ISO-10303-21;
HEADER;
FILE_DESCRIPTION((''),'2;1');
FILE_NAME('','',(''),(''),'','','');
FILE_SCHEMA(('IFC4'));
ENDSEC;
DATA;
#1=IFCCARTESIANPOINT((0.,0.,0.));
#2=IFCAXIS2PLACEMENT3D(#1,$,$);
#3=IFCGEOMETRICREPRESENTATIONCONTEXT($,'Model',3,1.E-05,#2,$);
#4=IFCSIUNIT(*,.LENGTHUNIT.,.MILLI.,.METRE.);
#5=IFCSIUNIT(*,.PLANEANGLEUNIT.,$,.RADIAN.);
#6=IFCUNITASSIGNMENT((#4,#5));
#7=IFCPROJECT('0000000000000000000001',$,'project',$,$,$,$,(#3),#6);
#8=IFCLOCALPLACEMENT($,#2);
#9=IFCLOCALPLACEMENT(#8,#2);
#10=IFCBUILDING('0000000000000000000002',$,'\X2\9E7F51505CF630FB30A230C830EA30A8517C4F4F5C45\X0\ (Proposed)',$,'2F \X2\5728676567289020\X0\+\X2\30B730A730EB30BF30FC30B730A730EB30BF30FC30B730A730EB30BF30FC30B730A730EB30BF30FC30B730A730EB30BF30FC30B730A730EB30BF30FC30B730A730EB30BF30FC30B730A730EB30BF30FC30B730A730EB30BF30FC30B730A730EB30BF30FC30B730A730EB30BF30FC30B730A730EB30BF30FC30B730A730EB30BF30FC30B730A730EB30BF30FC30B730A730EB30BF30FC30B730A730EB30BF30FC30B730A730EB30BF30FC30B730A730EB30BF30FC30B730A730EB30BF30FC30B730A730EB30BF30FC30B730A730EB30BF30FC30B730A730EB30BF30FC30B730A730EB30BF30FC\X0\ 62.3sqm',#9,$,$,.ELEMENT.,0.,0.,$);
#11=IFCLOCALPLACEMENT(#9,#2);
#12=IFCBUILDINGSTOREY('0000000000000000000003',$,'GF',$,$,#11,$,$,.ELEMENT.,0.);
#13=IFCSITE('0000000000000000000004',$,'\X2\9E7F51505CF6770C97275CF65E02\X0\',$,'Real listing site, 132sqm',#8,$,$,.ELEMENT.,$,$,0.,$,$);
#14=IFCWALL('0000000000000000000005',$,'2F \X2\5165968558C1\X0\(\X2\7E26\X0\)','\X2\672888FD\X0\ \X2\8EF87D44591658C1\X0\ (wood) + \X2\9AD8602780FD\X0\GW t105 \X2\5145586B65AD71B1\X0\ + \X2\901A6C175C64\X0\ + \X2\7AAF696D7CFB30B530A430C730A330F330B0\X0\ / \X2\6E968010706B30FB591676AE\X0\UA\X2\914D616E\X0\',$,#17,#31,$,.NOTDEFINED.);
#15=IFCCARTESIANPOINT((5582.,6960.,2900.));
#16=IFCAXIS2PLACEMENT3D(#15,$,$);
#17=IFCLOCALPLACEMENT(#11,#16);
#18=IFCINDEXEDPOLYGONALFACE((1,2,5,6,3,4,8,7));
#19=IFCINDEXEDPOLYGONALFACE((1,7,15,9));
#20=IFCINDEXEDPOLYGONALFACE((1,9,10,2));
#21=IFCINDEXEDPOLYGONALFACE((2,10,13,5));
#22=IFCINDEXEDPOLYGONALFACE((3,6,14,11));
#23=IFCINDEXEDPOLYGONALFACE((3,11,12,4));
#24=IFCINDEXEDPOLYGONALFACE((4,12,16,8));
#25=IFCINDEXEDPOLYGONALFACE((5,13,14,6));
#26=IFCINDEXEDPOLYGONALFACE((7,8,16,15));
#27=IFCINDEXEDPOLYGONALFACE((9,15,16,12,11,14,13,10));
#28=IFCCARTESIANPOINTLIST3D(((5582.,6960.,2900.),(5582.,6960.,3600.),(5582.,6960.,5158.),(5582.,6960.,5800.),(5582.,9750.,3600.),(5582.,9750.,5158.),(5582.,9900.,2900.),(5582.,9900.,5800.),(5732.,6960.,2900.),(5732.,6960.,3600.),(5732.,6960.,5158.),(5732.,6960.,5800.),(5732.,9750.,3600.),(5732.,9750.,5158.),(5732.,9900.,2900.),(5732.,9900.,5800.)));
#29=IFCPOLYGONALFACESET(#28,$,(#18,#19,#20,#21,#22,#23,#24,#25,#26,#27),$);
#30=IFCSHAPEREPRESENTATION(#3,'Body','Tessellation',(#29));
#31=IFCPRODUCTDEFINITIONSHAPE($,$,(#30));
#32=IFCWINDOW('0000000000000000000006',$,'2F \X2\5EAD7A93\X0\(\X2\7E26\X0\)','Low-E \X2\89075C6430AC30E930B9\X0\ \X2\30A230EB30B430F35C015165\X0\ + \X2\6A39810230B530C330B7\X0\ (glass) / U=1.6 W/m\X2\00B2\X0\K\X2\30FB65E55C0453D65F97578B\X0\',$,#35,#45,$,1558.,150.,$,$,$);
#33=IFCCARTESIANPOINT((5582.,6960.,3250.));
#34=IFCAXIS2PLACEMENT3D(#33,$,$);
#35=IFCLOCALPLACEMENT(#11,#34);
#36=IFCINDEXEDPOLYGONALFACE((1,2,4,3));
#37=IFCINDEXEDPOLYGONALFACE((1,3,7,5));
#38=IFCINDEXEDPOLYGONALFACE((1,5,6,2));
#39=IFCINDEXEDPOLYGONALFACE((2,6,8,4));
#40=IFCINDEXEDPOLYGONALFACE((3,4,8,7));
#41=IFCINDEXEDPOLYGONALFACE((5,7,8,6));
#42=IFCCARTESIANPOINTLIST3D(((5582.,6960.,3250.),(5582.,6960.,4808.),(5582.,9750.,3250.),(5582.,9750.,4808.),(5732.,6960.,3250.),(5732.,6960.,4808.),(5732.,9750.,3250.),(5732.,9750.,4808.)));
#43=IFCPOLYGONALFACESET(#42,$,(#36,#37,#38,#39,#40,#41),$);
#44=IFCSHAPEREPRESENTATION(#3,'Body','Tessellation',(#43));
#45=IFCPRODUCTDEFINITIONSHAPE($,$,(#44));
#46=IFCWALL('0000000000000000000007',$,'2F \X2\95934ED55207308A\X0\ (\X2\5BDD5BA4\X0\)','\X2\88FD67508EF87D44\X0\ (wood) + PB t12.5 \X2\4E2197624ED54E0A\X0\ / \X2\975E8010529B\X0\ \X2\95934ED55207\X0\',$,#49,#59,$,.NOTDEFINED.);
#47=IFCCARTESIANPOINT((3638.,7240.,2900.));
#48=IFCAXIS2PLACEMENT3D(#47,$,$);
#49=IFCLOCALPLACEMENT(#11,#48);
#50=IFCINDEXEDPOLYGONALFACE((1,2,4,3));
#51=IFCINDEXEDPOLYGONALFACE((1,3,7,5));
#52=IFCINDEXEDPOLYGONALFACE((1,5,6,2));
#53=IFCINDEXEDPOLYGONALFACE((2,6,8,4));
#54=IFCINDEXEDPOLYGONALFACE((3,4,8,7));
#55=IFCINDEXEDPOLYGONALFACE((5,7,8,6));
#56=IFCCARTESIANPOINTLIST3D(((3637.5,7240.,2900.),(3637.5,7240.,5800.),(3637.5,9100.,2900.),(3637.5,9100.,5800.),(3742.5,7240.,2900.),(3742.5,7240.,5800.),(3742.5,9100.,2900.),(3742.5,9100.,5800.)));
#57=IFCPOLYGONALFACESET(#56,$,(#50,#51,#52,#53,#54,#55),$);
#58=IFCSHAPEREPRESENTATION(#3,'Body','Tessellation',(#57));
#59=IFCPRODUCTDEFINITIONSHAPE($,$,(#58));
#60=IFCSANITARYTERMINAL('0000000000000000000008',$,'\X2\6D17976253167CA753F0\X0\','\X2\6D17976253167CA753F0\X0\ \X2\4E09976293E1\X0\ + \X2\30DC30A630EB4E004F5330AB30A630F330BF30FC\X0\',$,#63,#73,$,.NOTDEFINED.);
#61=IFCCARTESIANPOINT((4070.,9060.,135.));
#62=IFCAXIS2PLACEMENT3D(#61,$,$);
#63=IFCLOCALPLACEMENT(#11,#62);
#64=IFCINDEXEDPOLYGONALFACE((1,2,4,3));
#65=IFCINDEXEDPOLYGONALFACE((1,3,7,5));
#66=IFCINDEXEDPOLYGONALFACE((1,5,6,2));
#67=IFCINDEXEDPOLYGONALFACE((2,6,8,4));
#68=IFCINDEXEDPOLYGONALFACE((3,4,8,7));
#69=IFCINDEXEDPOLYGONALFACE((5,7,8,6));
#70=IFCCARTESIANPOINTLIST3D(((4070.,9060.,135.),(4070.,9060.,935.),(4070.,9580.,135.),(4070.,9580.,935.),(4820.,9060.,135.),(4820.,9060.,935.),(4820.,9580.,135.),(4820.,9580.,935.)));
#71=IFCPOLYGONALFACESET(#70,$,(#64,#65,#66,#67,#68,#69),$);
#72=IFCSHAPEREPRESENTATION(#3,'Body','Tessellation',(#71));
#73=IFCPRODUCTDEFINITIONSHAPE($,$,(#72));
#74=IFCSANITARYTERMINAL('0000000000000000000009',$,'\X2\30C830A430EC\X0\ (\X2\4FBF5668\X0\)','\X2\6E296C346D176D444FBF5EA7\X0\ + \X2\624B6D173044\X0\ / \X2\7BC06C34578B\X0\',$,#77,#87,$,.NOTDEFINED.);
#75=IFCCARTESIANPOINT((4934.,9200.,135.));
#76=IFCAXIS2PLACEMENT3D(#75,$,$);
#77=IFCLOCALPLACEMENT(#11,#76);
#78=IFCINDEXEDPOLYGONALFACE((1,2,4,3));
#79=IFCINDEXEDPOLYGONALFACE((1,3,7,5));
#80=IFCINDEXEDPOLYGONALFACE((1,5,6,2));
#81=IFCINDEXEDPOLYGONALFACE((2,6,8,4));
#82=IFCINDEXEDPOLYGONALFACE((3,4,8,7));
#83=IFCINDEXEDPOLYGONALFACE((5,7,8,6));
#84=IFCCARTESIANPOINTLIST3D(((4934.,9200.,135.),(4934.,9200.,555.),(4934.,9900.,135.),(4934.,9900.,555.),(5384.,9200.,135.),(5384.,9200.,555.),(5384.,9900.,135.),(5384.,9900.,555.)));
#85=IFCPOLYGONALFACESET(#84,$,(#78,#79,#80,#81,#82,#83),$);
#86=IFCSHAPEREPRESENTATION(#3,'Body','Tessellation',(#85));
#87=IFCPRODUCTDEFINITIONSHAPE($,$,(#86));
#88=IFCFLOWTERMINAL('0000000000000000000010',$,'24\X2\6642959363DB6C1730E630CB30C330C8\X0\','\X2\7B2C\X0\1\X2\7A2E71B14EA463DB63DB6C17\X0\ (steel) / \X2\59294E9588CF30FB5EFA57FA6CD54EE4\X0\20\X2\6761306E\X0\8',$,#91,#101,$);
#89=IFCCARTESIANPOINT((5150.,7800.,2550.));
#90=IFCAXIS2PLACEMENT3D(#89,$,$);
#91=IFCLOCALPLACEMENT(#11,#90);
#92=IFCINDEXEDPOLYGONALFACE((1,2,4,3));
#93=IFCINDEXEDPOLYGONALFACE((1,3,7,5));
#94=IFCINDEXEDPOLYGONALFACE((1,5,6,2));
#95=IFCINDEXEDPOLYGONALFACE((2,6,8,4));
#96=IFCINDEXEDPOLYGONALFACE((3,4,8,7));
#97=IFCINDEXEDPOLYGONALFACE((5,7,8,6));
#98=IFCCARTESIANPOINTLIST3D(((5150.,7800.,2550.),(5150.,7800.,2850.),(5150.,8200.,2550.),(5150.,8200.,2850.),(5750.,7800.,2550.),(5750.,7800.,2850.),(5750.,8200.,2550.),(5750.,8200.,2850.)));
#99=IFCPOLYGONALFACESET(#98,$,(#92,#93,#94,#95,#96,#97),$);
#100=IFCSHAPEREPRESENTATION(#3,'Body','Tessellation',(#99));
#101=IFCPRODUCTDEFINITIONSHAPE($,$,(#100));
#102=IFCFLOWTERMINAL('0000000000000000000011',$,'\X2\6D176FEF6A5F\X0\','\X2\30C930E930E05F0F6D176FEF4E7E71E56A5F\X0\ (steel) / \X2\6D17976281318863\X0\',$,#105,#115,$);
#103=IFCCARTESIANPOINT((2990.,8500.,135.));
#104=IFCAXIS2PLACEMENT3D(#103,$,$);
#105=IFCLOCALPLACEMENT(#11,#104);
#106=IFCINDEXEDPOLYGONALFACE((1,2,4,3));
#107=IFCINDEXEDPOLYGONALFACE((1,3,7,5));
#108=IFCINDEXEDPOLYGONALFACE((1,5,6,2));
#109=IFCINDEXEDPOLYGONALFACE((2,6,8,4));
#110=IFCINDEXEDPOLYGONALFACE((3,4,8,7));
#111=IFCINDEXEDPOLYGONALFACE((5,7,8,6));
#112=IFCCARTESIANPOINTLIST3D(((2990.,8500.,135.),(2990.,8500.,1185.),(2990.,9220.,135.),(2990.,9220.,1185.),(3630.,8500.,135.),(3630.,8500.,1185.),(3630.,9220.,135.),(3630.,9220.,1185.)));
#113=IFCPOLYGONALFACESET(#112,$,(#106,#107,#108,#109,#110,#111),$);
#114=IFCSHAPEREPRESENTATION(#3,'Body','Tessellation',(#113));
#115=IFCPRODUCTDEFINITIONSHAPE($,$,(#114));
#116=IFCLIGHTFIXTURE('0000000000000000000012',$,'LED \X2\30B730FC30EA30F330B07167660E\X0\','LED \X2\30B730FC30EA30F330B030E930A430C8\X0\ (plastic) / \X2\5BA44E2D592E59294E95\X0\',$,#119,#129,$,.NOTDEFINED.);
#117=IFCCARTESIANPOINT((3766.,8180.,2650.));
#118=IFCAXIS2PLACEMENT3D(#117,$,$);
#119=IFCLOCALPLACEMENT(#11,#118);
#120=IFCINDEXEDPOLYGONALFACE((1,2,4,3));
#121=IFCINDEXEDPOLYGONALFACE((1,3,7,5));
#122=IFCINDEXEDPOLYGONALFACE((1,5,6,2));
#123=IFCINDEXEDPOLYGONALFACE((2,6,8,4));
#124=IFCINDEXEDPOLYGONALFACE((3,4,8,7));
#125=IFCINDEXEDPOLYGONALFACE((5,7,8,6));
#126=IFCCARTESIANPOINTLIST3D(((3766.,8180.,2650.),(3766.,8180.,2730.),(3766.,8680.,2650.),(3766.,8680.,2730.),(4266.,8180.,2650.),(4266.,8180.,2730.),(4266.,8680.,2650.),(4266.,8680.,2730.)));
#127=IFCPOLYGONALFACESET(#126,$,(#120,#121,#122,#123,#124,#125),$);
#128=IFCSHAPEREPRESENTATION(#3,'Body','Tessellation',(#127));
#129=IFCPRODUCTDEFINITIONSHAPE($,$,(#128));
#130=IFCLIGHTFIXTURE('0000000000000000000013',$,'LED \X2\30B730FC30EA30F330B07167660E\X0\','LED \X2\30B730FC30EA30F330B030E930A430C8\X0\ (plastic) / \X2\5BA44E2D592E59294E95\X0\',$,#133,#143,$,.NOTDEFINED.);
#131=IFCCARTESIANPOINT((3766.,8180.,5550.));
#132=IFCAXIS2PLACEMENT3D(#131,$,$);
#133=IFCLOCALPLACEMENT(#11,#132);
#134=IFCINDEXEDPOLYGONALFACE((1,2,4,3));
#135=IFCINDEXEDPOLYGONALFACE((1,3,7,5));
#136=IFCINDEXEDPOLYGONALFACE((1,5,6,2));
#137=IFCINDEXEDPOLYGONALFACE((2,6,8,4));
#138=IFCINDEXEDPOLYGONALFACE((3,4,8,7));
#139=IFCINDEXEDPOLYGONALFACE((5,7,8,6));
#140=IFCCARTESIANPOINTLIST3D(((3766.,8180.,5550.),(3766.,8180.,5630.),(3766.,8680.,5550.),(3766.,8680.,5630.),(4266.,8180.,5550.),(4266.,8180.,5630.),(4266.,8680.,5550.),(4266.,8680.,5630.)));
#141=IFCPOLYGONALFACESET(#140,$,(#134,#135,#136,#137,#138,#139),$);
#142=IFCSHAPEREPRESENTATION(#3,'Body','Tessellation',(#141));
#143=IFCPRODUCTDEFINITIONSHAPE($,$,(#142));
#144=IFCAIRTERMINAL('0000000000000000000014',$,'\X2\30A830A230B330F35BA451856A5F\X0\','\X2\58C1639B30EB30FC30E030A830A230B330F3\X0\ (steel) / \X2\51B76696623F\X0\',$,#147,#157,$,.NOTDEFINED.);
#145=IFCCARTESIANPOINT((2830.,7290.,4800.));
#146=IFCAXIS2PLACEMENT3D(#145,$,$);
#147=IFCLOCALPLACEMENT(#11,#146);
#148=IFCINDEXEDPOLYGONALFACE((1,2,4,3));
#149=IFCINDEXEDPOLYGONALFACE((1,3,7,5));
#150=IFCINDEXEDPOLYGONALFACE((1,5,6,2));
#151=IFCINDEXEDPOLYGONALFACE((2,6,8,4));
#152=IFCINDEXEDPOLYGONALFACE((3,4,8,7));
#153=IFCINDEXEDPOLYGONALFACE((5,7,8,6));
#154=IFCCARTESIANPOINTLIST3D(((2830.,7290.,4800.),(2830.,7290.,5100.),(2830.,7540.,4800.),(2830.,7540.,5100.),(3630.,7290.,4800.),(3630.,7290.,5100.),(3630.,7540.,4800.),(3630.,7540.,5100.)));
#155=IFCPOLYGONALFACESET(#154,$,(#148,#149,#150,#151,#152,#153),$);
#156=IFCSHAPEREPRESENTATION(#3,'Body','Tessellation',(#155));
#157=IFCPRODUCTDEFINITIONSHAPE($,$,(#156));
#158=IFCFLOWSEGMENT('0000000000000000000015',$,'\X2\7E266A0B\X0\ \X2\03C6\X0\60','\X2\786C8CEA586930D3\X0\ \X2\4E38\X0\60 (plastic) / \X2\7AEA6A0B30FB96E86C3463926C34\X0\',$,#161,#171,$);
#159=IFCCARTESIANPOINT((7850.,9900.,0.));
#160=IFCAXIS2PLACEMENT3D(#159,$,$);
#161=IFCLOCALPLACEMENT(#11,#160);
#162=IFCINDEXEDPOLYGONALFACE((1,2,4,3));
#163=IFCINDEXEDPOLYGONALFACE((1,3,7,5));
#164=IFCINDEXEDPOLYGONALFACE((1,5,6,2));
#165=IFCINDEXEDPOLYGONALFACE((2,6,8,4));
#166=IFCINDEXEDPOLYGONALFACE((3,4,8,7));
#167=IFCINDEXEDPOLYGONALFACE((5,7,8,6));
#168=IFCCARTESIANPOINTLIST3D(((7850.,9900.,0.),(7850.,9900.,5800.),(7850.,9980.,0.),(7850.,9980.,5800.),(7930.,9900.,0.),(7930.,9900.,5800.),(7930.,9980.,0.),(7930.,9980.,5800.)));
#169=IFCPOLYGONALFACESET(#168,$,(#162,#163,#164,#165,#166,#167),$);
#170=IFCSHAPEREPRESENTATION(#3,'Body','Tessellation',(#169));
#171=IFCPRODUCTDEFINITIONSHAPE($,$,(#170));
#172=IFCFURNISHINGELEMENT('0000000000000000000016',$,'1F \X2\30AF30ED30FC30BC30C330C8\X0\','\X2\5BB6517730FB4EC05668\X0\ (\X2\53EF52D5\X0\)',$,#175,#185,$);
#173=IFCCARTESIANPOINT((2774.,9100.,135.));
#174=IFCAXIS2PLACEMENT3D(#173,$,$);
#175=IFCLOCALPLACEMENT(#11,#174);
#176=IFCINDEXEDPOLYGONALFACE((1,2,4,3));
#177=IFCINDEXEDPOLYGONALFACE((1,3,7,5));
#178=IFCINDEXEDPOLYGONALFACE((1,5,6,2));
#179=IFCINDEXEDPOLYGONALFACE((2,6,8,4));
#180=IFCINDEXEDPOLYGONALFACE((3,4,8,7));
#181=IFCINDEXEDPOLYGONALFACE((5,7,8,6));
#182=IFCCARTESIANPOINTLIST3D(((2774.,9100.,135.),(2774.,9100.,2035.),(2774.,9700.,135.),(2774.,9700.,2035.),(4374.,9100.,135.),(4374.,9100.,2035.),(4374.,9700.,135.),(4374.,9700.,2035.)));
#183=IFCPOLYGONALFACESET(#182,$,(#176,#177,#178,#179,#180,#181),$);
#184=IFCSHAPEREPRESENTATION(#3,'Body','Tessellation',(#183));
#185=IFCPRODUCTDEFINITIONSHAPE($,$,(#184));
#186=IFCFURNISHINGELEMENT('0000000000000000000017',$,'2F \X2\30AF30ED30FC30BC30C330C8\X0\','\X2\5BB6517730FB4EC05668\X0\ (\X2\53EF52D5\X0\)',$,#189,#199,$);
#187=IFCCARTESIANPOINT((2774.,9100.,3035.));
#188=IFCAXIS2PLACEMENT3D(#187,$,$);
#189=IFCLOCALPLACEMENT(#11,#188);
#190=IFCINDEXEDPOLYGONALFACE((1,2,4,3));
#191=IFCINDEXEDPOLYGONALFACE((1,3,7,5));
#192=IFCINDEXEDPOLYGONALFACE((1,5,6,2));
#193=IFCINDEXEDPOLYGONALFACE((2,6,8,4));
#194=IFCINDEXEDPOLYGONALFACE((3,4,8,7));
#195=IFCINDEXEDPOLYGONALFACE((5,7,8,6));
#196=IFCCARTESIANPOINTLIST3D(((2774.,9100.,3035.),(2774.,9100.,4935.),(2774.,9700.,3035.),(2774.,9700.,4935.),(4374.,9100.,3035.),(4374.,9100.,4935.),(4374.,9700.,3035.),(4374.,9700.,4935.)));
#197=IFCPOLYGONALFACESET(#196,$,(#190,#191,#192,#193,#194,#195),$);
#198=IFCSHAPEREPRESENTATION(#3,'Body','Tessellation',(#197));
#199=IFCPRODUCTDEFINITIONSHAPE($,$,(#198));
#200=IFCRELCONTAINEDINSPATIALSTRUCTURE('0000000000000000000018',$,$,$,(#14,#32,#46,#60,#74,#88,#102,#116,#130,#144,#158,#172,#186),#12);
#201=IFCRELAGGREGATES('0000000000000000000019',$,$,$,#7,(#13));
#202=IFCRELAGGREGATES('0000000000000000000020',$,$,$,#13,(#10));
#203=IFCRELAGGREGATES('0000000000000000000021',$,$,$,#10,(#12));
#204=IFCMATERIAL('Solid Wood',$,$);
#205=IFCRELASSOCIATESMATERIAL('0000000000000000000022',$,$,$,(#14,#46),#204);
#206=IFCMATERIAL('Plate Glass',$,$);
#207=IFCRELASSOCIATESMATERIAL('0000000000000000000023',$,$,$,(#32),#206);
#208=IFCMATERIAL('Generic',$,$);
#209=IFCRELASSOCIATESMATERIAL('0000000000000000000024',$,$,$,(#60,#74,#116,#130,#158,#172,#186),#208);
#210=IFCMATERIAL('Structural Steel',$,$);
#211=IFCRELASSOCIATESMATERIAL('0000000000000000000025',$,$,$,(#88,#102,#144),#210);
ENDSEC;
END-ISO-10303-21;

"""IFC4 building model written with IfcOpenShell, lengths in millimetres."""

from ifc_helpers import new_model, si_unit, frame, frame_2d, origin, place, context, project, spatial, rectangle, extrude, material, element, fill, save


model = new_model("IFC4")

# Units and contexts
model_context = context("Model", 3, precision=1e-05, world=origin())
ifc_project = project(units=[si_unit("LENGTHUNIT", "METRE", prefix="MILLI"), si_unit("PLANEANGLEUNIT", "RADIAN")], contexts=[model_context])

# Site, building, storey
site_placement = place(None, origin())
site = spatial("IfcSite", under=ifc_project, at=site_placement, Name="鹿児島県霧島市", ObjectType="Real listing site, 132sqm", CompositionType="ELEMENT", RefElevation=0.0)
building_placement = place(site_placement, origin())
building = spatial("IfcBuilding", under=site, at=building_placement, Name="鹿児島・アトリエ兼住居 (Proposed)", ObjectType="2F 在来木造+シェルターシェルターシェルターシェルターシェルターシェルターシェルターシェルターシェルターシェルターシェルターシェルターシェルターシェルターシェルターシェルターシェルターシェルターシェルターシェルターシェルターシェルターシェルター 62.3sqm", CompositionType="ELEMENT", ElevationOfRefHeight=0.0, ElevationOfTerrain=0.0)
storey_placement = place(building_placement, origin())
storey = spatial("IfcBuildingStorey", under=building, at=storey_placement, Name="GF", CompositionType="ELEMENT", Elevation=0.0)

# Shared definitions
ifc_material_1 = material(Name="Solid Wood")

# Shared definitions
ifc_material_2 = material(Name="Plate Glass")

# Wall, opening, window
wall_1_placement = place(storey_placement, frame((5582.0, 6960.0, 2900.0)))
wall_1 = element("IfcWall", 1, at=wall_1_placement, inside=storey, material=ifc_material_1, Name="2F 入隅壁(縦)", Description="木製 軸組外壁 (wood) + 高性能GW t105 充填断熱 + 通気層 + 窯業系サイディング / 準耐火・外皮UA配慮", PredefinedType="NOTDEFINED", context=model_context, shape_type="SweptSolid", body=[
    extrude(rectangle(XDim=150.0, YDim=2940.0, at=frame_2d((75.0, 1470.0))), frame((5582.0, 6960.0, 2900.0)), (0.0, 0.0, 1.0), 2900.0),
])
opening_1_placement = place(storey_placement, frame((5582.0, 6960.0, 3250.0)))
opening_1 = element("IfcOpeningElement", 2, at=opening_1_placement, cuts=wall_1, PredefinedType="NOTDEFINED", context=model_context, shape_type="SweptSolid", body=[
    extrude(rectangle(XDim=150.0, YDim=2790.0, at=frame_2d((75.0, 1395.0))), frame((5582.0, 6960.0, 3250.0)), (0.0, 0.0, 1.0), 1558.0),
])
window_1_placement = place(storey_placement, frame((5582.0, 6960.0, 3250.0)))
window_1 = element("IfcWindow", 3, at=window_1_placement, inside=storey, material=ifc_material_2, Name="2F 庭窓(縦)", Description="Low-E 複層ガラス アルゴン封入 + 樹脂サッシ (glass) / U=1.6 W/m²K・日射取得型", OverallHeight=1558.0, OverallWidth=150.0, context=model_context, shape_type="SweptSolid", body=[
    extrude(rectangle(XDim=150.0, YDim=2790.0, at=frame_2d((75.0, 1395.0))), frame((5582.0, 6960.0, 3250.0)), (0.0, 0.0, 1.0), 1558.0),
])
fill(opening_1, window_1)

# Wall
wall_2_placement = place(storey_placement, frame((3638.0, 7240.0, 2900.0)))
element("IfcWall", 4, at=wall_2_placement, inside=storey, material=ifc_material_1, Name="2F 間仕切り (寝室)", Description="製材軸組 (wood) + PB t12.5 両面仕上 / 非耐力 間仕切", PredefinedType="NOTDEFINED", context=model_context, shape_type="SweptSolid", body=[
    extrude(rectangle(XDim=105.0, YDim=1860.0, at=frame_2d((52.0, 930.0))), frame((3638.0, 7240.0, 2900.0)), (0.0, 0.0, 1.0), 2900.0),
])

# Sanitary terminals
ifc_material_3 = material(Name="Generic")
sanitary_terminal_1_placement = place(storey_placement, frame((4070.0, 9060.0, 135.0)))
element("IfcSanitaryTerminal", 5, at=sanitary_terminal_1_placement, inside=storey, material=ifc_material_3, Name="洗面化粧台", Description="洗面化粧台 三面鏡 + ボウル一体カウンター", PredefinedType="NOTDEFINED", context=model_context, shape_type="SweptSolid", body=[
    extrude(rectangle(XDim=750.0, YDim=520.0, at=frame_2d((375.0, 260.0))), frame((4070.0, 9060.0, 135.0)), (0.0, 0.0, 1.0), 800.0),
])
sanitary_terminal_2_placement = place(storey_placement, frame((4934.0, 9200.0, 135.0)))
element("IfcSanitaryTerminal", 6, at=sanitary_terminal_2_placement, inside=storey, material=ifc_material_3, Name="トイレ (便器)", Description="温水洗浄便座 + 手洗い / 節水型", PredefinedType="NOTDEFINED", context=model_context, shape_type="SweptSolid", body=[
    extrude(rectangle(XDim=450.0, YDim=700.0, at=frame_2d((225.0, 350.0))), frame((4934.0, 9200.0, 135.0)), (0.0, 0.0, 1.0), 420.0),
])

# Flow terminals
ifc_material_4 = material(Name="Structural Steel")
flow_terminal_1_placement = place(storey_placement, frame((5150.0, 7800.0, 2550.0)))
element("IfcFlowTerminal", 7, at=flow_terminal_1_placement, inside=storey, material=ifc_material_4, Name="24時間換気ユニット", Description="第1種熱交換換気 (steel) / 天井裏・建基法令20条の8", context=model_context, shape_type="SweptSolid", body=[
    extrude(rectangle(XDim=600.0, YDim=400.0, at=frame_2d((300.0, 200.0))), frame((5150.0, 7800.0, 2550.0)), (0.0, 0.0, 1.0), 300.0),
])
flow_terminal_2_placement = place(storey_placement, frame((2990.0, 8500.0, 135.0)))
element("IfcFlowTerminal", 8, at=flow_terminal_2_placement, inside=storey, material=ifc_material_4, Name="洗濯機", Description="ドラム式洗濯乾燥機 (steel) / 洗面脱衣", context=model_context, shape_type="SweptSolid", body=[
    extrude(rectangle(XDim=640.0, YDim=720.0, at=frame_2d((320.0, 360.0))), frame((2990.0, 8500.0, 135.0)), (0.0, 0.0, 1.0), 1050.0),
])

# Light fixtures
light_fixture_1_placement = place(storey_placement, frame((3766.0, 8180.0, 2650.0)))
element("IfcLightFixture", 9, at=light_fixture_1_placement, inside=storey, material=ifc_material_3, Name="LED シーリング照明", Description="LED シーリングライト (plastic) / 室中央天井", PredefinedType="NOTDEFINED", context=model_context, shape_type="SweptSolid", body=[
    extrude(rectangle(XDim=500.0, YDim=500.0, at=frame_2d((250.0, 250.0))), frame((3766.0, 8180.0, 2650.0)), (0.0, 0.0, 1.0), 80.0),
])
light_fixture_2_placement = place(storey_placement, frame((3766.0, 8180.0, 5550.0)))
element("IfcLightFixture", 10, at=light_fixture_2_placement, inside=storey, material=ifc_material_3, Name="LED シーリング照明", Description="LED シーリングライト (plastic) / 室中央天井", PredefinedType="NOTDEFINED", context=model_context, shape_type="SweptSolid", body=[
    extrude(rectangle(XDim=500.0, YDim=500.0, at=frame_2d((250.0, 250.0))), frame((3766.0, 8180.0, 5550.0)), (0.0, 0.0, 1.0), 80.0),
])

# Air terminal
air_terminal_placement = place(storey_placement, frame((2830.0, 7290.0, 4800.0)))
element("IfcAirTerminal", 11, at=air_terminal_placement, inside=storey, material=ifc_material_4, Name="エアコン室内機", Description="壁掛ルームエアコン (steel) / 冷暖房", PredefinedType="NOTDEFINED", context=model_context, shape_type="SweptSolid", body=[
    extrude(rectangle(XDim=800.0, YDim=250.0, at=frame_2d((400.0, 125.0))), frame((2830.0, 7290.0, 4800.0)), (0.0, 0.0, 1.0), 300.0),
])

# Flow segment
flow_segment_placement = place(storey_placement, frame((7850.0, 9900.0, 0.0)))
element("IfcFlowSegment", 12, at=flow_segment_placement, inside=storey, material=ifc_material_3, Name="縦樋 φ60", Description="硬質塩ビ 丸60 (plastic) / 竪樋・雨水排水", context=model_context, shape_type="SweptSolid", body=[
    extrude(rectangle(XDim=80.0, YDim=80.0, at=frame_2d((40.0, 40.0))), frame((7850.0, 9900.0, 0.0)), (0.0, 0.0, 1.0), 5800.0),
])

# Furnishing elements
furnishing_1_placement = place(storey_placement, frame((2774.0, 9100.0, 135.0)))
element("IfcFurnishingElement", 13, at=furnishing_1_placement, inside=storey, material=ifc_material_3, Name="1F クローゼット", Description="家具・什器 (可動)", context=model_context, shape_type="SweptSolid", body=[
    extrude(rectangle(XDim=1600.0, YDim=600.0, at=frame_2d((800.0, 300.0))), frame((2774.0, 9100.0, 135.0)), (0.0, 0.0, 1.0), 1900.0),
])
furnishing_2_placement = place(storey_placement, frame((2774.0, 9100.0, 3035.0)))
element("IfcFurnishingElement", 14, at=furnishing_2_placement, inside=storey, material=ifc_material_3, Name="2F クローゼット", Description="家具・什器 (可動)", context=model_context, shape_type="SweptSolid", body=[
    extrude(rectangle(XDim=1600.0, YDim=600.0, at=frame_2d((800.0, 300.0))), frame((2774.0, 9100.0, 3035.0)), (0.0, 0.0, 1.0), 1900.0),
])

save(model, "model.ifc")
